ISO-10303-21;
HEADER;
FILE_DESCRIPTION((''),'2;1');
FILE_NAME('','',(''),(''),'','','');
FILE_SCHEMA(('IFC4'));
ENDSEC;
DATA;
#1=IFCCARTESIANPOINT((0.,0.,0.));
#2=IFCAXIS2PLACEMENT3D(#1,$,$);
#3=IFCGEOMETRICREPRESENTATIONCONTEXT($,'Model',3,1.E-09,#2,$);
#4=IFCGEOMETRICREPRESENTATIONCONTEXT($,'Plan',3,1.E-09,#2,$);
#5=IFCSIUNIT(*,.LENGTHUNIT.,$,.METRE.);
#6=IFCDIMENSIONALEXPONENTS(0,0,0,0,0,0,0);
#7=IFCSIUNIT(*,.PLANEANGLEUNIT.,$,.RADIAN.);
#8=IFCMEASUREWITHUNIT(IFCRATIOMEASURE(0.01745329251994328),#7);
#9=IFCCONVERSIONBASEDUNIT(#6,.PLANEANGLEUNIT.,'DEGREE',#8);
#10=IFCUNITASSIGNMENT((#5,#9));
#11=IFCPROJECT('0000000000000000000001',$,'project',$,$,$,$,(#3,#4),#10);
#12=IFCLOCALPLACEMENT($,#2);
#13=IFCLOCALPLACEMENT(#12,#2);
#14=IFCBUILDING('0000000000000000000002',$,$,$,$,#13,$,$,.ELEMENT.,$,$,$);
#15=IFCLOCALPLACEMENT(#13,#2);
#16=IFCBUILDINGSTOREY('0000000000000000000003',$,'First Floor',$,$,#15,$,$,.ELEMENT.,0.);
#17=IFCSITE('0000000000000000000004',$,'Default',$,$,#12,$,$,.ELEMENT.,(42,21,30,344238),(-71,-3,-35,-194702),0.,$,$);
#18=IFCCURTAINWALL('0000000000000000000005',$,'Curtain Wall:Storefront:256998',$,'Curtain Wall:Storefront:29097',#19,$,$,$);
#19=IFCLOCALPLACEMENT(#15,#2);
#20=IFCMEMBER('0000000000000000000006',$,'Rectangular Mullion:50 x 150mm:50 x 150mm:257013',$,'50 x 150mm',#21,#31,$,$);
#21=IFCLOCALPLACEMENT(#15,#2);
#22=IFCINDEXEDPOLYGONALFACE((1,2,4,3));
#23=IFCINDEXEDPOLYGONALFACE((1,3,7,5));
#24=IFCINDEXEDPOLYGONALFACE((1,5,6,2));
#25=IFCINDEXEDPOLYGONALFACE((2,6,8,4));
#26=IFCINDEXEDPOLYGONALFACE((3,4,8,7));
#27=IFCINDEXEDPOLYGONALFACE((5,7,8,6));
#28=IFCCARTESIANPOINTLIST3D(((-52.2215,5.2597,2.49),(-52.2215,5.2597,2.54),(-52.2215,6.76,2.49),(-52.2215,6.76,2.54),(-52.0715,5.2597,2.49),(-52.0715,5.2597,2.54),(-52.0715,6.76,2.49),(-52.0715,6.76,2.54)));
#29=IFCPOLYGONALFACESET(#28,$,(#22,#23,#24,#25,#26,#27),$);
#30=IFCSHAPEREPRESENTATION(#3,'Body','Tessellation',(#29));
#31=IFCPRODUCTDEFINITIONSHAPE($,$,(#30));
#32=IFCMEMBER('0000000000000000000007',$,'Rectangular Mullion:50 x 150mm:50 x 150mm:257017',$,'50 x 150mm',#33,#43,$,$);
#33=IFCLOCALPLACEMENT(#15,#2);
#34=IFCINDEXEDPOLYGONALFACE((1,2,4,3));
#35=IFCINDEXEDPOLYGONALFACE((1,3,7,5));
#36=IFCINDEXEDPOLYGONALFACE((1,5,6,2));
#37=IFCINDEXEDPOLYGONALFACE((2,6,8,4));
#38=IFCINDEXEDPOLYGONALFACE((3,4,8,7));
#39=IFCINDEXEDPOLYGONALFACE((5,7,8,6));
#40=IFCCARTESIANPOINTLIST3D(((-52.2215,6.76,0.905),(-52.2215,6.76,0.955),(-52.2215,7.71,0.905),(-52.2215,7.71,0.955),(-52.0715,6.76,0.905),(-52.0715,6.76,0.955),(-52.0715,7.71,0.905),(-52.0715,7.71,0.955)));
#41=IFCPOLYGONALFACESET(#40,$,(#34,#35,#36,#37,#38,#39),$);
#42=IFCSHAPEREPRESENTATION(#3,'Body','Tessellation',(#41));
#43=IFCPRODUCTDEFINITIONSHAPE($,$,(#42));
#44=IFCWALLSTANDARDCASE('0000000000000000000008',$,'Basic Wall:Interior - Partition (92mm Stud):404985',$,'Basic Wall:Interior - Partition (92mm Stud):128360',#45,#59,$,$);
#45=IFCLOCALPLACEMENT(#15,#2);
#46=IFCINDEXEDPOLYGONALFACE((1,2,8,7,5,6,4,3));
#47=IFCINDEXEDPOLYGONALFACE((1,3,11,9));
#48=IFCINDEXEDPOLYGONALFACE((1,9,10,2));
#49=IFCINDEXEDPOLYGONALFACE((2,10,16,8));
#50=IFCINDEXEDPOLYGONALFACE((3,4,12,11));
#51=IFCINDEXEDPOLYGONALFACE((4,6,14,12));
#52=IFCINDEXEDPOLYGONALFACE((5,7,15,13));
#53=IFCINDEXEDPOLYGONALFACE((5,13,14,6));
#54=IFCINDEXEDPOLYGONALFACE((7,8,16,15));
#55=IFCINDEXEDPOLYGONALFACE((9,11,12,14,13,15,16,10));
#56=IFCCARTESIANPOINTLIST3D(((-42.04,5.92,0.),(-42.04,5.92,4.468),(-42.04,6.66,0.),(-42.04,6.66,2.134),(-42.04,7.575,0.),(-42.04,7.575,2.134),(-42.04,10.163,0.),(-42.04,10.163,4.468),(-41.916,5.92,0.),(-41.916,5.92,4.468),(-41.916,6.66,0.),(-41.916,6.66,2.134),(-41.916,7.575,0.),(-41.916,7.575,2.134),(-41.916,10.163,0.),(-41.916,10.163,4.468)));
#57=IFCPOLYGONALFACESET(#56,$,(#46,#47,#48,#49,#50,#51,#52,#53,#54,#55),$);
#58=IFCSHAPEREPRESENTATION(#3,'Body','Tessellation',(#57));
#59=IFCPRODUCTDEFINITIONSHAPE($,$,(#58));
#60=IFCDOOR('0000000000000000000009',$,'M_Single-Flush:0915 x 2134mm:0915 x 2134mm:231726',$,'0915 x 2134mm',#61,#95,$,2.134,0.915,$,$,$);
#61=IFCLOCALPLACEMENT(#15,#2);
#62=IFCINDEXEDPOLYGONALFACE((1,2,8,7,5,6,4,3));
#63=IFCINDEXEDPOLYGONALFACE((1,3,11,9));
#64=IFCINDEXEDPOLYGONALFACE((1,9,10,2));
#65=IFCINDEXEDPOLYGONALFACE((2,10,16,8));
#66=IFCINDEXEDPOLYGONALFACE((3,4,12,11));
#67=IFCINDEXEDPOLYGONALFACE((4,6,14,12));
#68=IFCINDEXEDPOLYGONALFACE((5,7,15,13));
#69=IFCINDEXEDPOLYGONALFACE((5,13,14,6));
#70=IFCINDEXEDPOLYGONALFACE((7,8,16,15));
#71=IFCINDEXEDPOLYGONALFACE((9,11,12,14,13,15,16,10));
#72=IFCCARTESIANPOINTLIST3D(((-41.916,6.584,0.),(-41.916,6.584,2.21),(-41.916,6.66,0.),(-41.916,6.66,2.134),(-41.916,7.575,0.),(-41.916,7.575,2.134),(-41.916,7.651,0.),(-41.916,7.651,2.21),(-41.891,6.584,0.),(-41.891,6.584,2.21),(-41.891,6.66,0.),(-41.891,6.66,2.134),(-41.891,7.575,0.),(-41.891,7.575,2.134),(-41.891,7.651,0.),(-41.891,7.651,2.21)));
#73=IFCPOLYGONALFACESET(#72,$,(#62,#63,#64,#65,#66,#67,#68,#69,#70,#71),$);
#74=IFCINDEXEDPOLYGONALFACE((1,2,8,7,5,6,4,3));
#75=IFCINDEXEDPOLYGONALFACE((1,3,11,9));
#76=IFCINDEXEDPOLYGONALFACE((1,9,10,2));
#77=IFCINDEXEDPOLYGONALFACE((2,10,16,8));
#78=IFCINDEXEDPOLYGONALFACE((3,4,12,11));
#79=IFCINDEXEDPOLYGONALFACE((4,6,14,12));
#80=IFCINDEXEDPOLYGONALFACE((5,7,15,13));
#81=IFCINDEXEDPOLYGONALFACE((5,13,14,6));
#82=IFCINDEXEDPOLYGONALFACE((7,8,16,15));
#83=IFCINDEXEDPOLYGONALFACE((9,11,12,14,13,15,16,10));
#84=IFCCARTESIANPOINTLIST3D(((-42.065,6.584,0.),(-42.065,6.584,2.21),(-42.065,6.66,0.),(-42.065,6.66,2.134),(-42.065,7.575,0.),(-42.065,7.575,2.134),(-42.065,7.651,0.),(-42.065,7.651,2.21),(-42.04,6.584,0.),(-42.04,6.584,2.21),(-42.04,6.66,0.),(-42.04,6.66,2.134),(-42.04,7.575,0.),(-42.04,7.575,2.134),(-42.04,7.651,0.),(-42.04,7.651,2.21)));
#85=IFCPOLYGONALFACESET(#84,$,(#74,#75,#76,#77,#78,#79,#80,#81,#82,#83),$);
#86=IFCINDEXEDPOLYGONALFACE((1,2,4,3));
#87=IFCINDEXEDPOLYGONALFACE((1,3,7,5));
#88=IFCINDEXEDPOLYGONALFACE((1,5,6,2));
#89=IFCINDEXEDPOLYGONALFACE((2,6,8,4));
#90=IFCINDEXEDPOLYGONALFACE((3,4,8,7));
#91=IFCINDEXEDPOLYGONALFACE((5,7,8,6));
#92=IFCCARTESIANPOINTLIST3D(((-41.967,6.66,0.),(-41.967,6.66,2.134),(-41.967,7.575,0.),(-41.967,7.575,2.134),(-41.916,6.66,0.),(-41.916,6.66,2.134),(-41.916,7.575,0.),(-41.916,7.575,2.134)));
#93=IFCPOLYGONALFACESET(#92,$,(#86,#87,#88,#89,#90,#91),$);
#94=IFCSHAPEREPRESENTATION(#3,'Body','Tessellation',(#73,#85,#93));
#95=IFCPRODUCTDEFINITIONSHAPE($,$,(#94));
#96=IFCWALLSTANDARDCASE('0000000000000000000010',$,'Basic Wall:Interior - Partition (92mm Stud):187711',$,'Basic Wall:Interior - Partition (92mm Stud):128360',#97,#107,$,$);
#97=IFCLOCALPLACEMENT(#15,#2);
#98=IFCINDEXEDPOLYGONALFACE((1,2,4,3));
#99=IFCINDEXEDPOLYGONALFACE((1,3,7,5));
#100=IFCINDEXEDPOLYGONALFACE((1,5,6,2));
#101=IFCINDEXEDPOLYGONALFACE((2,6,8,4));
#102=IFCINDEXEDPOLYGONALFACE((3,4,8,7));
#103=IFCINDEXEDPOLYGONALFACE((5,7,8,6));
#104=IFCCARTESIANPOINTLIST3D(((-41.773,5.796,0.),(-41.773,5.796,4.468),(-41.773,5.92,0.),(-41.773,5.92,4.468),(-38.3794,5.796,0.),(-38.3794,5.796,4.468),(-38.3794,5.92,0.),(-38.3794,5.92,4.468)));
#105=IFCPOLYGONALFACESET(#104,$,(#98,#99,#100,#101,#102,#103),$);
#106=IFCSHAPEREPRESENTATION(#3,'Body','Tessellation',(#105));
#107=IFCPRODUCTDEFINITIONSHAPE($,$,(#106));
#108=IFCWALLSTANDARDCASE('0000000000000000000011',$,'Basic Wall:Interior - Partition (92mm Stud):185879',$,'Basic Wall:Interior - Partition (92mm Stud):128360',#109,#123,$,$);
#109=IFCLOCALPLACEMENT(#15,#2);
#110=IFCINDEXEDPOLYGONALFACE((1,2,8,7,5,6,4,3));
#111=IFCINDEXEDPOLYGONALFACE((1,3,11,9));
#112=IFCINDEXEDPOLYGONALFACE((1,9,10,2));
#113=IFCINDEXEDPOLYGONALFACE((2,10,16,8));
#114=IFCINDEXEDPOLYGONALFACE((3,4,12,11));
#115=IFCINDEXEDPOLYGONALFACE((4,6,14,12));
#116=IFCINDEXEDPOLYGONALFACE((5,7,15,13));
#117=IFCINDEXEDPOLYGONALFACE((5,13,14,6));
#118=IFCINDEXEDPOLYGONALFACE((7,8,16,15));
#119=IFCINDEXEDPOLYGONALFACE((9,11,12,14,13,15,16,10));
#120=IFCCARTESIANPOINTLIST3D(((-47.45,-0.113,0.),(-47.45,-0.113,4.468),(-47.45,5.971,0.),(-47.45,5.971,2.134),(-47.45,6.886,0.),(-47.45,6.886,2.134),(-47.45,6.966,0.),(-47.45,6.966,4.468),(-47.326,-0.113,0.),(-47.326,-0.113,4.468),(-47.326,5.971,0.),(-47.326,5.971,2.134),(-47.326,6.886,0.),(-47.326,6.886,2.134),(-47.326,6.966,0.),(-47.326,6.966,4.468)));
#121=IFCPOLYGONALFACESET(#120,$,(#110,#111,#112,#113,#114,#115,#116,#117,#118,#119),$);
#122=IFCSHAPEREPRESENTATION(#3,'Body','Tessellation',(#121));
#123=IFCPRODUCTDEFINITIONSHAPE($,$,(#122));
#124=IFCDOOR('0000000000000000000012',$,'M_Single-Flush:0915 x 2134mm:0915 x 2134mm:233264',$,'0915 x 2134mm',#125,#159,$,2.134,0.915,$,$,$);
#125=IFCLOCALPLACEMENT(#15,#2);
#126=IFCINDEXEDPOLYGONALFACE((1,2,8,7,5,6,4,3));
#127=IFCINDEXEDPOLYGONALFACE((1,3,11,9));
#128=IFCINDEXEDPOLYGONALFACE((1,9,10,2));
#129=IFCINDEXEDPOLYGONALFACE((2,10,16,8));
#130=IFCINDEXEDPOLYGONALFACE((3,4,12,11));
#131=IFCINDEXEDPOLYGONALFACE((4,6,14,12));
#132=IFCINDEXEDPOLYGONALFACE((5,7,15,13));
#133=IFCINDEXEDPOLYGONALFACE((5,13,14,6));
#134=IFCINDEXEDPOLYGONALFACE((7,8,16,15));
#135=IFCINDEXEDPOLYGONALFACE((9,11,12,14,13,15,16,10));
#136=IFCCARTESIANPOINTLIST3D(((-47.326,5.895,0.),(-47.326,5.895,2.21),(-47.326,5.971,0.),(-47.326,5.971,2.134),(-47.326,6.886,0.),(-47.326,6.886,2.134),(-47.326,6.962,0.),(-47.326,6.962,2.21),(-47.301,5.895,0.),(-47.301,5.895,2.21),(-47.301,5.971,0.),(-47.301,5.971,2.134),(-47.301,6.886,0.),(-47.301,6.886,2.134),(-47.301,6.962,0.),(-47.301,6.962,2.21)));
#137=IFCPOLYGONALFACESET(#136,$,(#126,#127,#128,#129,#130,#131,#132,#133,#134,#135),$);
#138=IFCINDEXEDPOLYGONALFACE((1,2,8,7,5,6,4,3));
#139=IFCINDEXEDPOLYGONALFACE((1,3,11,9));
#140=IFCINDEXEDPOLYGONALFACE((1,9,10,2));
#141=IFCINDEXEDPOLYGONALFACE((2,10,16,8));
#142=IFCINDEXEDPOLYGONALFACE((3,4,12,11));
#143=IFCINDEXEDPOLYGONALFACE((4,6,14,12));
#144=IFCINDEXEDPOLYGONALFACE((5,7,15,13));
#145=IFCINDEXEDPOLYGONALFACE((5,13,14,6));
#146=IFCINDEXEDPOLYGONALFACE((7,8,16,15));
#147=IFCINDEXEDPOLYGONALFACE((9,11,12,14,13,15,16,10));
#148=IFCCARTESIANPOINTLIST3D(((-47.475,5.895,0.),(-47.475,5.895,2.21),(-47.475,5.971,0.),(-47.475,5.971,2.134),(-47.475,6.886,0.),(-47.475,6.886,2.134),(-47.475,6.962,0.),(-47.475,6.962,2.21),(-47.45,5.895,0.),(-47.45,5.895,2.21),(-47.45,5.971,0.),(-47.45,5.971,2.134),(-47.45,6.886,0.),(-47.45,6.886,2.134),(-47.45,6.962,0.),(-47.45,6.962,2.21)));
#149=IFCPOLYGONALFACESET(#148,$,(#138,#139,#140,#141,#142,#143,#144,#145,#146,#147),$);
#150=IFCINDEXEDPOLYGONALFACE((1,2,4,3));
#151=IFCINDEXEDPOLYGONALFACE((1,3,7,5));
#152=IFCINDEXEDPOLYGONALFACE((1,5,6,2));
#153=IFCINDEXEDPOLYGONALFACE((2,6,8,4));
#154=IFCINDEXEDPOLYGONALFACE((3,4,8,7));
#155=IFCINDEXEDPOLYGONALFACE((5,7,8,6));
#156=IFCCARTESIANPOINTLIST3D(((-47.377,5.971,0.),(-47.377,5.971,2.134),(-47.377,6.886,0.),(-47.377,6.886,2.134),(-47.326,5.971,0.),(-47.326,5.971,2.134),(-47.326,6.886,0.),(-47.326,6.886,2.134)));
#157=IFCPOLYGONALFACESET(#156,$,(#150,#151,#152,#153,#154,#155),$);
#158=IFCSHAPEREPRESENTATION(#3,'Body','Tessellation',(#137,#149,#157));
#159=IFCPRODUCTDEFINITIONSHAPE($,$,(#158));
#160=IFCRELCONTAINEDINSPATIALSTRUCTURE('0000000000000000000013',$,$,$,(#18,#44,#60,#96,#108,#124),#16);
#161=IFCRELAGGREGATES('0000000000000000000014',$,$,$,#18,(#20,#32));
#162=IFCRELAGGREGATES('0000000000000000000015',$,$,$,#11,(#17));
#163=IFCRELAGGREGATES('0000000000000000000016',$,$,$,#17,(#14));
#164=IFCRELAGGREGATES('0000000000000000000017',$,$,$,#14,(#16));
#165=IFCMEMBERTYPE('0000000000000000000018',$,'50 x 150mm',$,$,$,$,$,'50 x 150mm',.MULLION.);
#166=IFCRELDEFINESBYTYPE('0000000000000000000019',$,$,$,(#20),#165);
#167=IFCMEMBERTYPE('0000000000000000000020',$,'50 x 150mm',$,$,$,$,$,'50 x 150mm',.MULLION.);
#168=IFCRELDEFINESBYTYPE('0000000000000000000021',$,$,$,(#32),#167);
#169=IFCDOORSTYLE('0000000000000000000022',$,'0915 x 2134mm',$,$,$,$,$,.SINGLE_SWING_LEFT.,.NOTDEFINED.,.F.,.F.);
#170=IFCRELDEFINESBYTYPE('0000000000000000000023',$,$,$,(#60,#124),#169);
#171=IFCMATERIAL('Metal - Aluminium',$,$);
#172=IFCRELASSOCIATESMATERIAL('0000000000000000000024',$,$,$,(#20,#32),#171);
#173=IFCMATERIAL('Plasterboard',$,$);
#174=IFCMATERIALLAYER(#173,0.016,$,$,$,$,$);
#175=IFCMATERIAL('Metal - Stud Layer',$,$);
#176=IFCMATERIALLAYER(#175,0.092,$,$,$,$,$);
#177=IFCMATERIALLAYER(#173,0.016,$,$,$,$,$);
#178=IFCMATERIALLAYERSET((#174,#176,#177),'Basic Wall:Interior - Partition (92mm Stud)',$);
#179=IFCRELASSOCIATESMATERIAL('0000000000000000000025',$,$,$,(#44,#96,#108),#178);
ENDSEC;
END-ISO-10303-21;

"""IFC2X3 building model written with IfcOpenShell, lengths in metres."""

from ifc_helpers import new_model, entity, si_unit, converted_unit, frame, frame_2d, origin, origin_2d_with_axis, place, context, project, spatial, polyline, rectangle, outline, extrude, source, transform, mapped, material, layer, layer_set, layer_usage, type_object, type_shapes, element, fill, aggregate, save


model = new_model("IFC2X3")

# Units and contexts
model_context = context("Model", 3, precision=1e-09, world=origin())
plan_context = context("Plan", 3, precision=1e-09, world=origin())
ifc_project = project(units=[si_unit("LENGTHUNIT", "METRE"), converted_unit("PLANEANGLEUNIT", "DEGREE", entity("IfcRatioMeasure", 0.01745329251994328), si_unit("PLANEANGLEUNIT", "RADIAN"), dimensions=[0, 0, 0, 0, 0, 0, 0])], contexts=[model_context, plan_context])

# Site, building, storey
site_placement = place(None, origin())
site = spatial("IfcSite", under=ifc_project, at=site_placement, Name="Default", CompositionType="ELEMENT", RefLatitude=(42, 21, 30, 344238), RefLongitude=(-71, -3, -35, -194702), RefElevation=0.0)
building_placement = place(site_placement, origin())
building = spatial("IfcBuilding", under=site, at=building_placement, CompositionType="ELEMENT")
storey_placement = place(building_placement, origin())
storey = spatial("IfcBuildingStorey", under=building, at=storey_placement, Name="First Floor", CompositionType="ELEMENT", Elevation=0.0)

# Curtain wall, members
curtain_wall_placement = place(storey_placement, origin())
curtain_wall = element("IfcCurtainWall", 1, at=curtain_wall_placement, inside=storey, Name="Curtain Wall:Storefront:256998", ObjectType="Curtain Wall:Storefront:29097")
ifc_material_1 = material(Name="Metal - Aluminium")
member_type_1 = type_object("IfcMemberType", Name="50 x 150mm", ElementType="50 x 150mm", PredefinedType="MULLION")
shared_shape_1 = source(origin(), model_context, "Body", "SweptSolid", [
    extrude(rectangle(XDim=0.05, YDim=0.15, at=origin_2d_with_axis()), frame((-0.025, 0.0, -1.5003), z_axis=(0.0, 0.0, 1.0), x_axis=(-1.0, 0.0, 0.0)), (0.0, 0.0, 1.0), 1.5003),
])
type_shapes(member_type_1, [shared_shape_1])
member_1_placement = place(storey_placement, frame((-52.1465, 6.76, 2.54), z_axis=(0.0, 1.0, 0.0), x_axis=(0.0, 0.0, 1.0)))
member_1 = element("IfcMember", 2, at=member_1_placement, type_object=member_type_1, material=ifc_material_1, Name="Rectangular Mullion:50 x 150mm:50 x 150mm:257013", ObjectType="50 x 150mm", context=model_context, shape_type="MappedRepresentation", body=[
    mapped(shared_shape_1, transform((0.0, 0.0, 0.0), scale=1.0)),
])
member_type_2 = type_object("IfcMemberType", Name="50 x 150mm", ElementType="50 x 150mm", PredefinedType="MULLION")
shared_shape_2 = source(origin(), model_context, "Body", "SweptSolid", [
    extrude(rectangle(XDim=0.05, YDim=0.15, at=origin_2d_with_axis()), frame((-0.025, 0.0, -0.95), z_axis=(0.0, 0.0, 1.0), x_axis=(-1.0, 0.0, 0.0)), (0.0, 0.0, 1.0), 0.95),
])
type_shapes(member_type_2, [shared_shape_2])
member_2_placement = place(storey_placement, frame((-52.1465, 6.76, 0.905), z_axis=(0.0, -1.0, 0.0), x_axis=(0.0, 0.0, -1.0)))
member_2 = element("IfcMember", 3, at=member_2_placement, type_object=member_type_2, material=ifc_material_1, Name="Rectangular Mullion:50 x 150mm:50 x 150mm:257017", ObjectType="50 x 150mm", context=model_context, shape_type="MappedRepresentation", body=[
    mapped(shared_shape_2, transform((0.0, 0.0, 0.0), scale=1.0)),
])
aggregate(curtain_wall, [member_1, member_2])

# Wall, opening, door
ifc_material_2 = material(Name="Plasterboard")
ifc_layer_1 = layer(ifc_material_2, 0.016)
ifc_material_3 = material(Name="Metal - Stud Layer")
ifc_layer_2 = layer(ifc_material_3, 0.092)
ifc_layer_3 = layer(ifc_material_2, 0.016)
ifc_layer_set_1 = layer_set([ifc_layer_1, ifc_layer_2, ifc_layer_3], Name="Basic Wall:Interior - Partition (92mm Stud)")
ifc_layer_usage_1 = layer_usage(ifc_layer_set_1, "AXIS2", "NEGATIVE", 0.062)
wall_1_placement = place(storey_placement, frame((-41.978, 5.92, 0.0), z_axis=(0.0, 0.0, 1.0), x_axis=(0.0, 1.0, 0.0)))
wall_1 = element("IfcWallStandardCase", 4, at=wall_1_placement, inside=storey, material=ifc_layer_usage_1, Name="Basic Wall:Interior - Partition (92mm Stud):404985", ObjectType="Basic Wall:Interior - Partition (92mm Stud):128360", context=model_context, shape_type="SweptSolid", body=[
    extrude(rectangle(XDim=4.243, YDim=0.124, at=frame_2d((2.1215, 0.0), x_axis=(-1.0, 0.0))), origin(), (0.0, 0.0, 1.0), 4.468),
])
opening_1_placement = place(wall_1_placement, frame((1.655, 0.062, 0.0)))
opening_1 = element("IfcOpeningElement", 5, at=opening_1_placement, cuts=wall_1, ObjectType="Opening", context=model_context, shape_type="SweptSolid", body=[
    extrude(rectangle(XDim=0.915, YDim=2.134, at=frame_2d((1.067, 0.4575), x_axis=(0.0, -1.0))), frame((0.0, 0.0, 0.0), z_axis=(0.0, -1.0, 0.0), x_axis=(0.0, 0.0, 1.0)), (0.0, 0.0, 1.0), 0.124),
])
door_style_1 = type_object("IfcDoorStyle", Name="0915 x 2134mm", ConstructionType="NOTDEFINED", OperationType="SINGLE_SWING_LEFT", ParameterTakesPrecedence=False, Sizeable=False)
shared_shape_3 = source(origin(), model_context, "Body", "SweptSolid", [
    extrude(outline(polyline([(-0.5335, -1.124), (0.5335, -1.124), (0.5335, 1.086), (0.4575, 1.086), (0.4575, -1.048), (-0.4575, -1.048), (-0.4575, 1.086), (-0.5335, 1.086), (-0.5335, -1.124)])), frame((0.4575, 0.149, 1.086), z_axis=(0.0, -1.0, 0.0), x_axis=(-1.0, 0.0, 0.0)), (0.0, 0.0, 1.0), 0.025),
    extrude(outline(polyline([(-1.124, -0.5335), (1.086, -0.5335), (1.086, -0.4575), (-1.048, -0.4575), (-1.048, 0.4575), (1.086, 0.4575), (1.086, 0.5335), (-1.124, 0.5335), (-1.124, -0.5335)])), frame((0.4575, 0.0, 1.086), z_axis=(0.0, -1.0, 0.0), x_axis=(0.0, 0.0, -1.0)), (0.0, 0.0, 1.0), 0.025),
    extrude(rectangle(XDim=0.915, YDim=0.051, at=origin_2d_with_axis()), frame((0.4575, 0.0985, 0.0)), (0.0, 0.0, 1.0), 2.134),
])
type_shapes(door_style_1, [shared_shape_3])
door_1_placement = place(opening_1_placement, frame((0.0, 0.0, 0.0), z_axis=(0.0, 0.0, 1.0), x_axis=(-1.0, 0.0, 0.0)))
door_1 = element("IfcDoor", 6, at=door_1_placement, inside=storey, type_object=door_style_1, Name="M_Single-Flush:0915 x 2134mm:0915 x 2134mm:231726", ObjectType="0915 x 2134mm", OverallHeight=2.134, OverallWidth=0.915, context=model_context, shape_type="MappedRepresentation", body=[
    mapped(shared_shape_3, transform((0.0, 0.0, 0.0), scale=1.0)),
])
fill(opening_1, door_1)

# Wall
wall_2_placement = place(storey_placement, frame((-41.773, 5.858, 0.0)))
element("IfcWallStandardCase", 7, at=wall_2_placement, inside=storey, material=ifc_layer_usage_1, Name="Basic Wall:Interior - Partition (92mm Stud):187711", ObjectType="Basic Wall:Interior - Partition (92mm Stud):128360", context=model_context, shape_type="SweptSolid", body=[
    extrude(rectangle(XDim=3.3936, YDim=0.124, at=frame_2d((1.6968, 0.0), x_axis=(-1.0, 0.0))), origin(), (0.0, 0.0, 1.0), 4.468),
])

# Wall, opening, door
wall_3_placement = place(storey_placement, frame((-47.388, -0.113, 0.0), z_axis=(0.0, 0.0, 1.0), x_axis=(0.0, 1.0, 0.0)))
wall_3 = element("IfcWallStandardCase", 8, at=wall_3_placement, inside=storey, material=ifc_layer_usage_1, Name="Basic Wall:Interior - Partition (92mm Stud):185879", ObjectType="Basic Wall:Interior - Partition (92mm Stud):128360", context=model_context, shape_type="SweptSolid", body=[
    extrude(rectangle(XDim=7.079, YDim=0.124, at=frame_2d((3.5395, 0.0), x_axis=(-1.0, 0.0))), origin(), (0.0, 0.0, 1.0), 4.468),
])
opening_2_placement = place(wall_3_placement, frame((6.999, 0.062, 0.0)))
opening_2 = element("IfcOpeningElement", 9, at=opening_2_placement, cuts=wall_3, ObjectType="Opening", context=model_context, shape_type="SweptSolid", body=[
    extrude(rectangle(XDim=0.915, YDim=2.134, at=frame_2d((1.067, 0.4575), x_axis=(0.0, -1.0))), frame((0.0, 0.0, 0.0), z_axis=(0.0, -1.0, 0.0), x_axis=(0.0, 0.0, 1.0)), (0.0, 0.0, 1.0), 0.124),
])
door_2_placement = place(opening_2_placement, frame((0.0, 0.0, 0.0), z_axis=(0.0, 0.0, 1.0), x_axis=(-1.0, 0.0, 0.0)))
door_2 = element("IfcDoor", 10, at=door_2_placement, inside=storey, type_object=door_style_1, Name="M_Single-Flush:0915 x 2134mm:0915 x 2134mm:233264", ObjectType="0915 x 2134mm", OverallHeight=2.134, OverallWidth=0.915, context=model_context, shape_type="MappedRepresentation", body=[
    mapped(shared_shape_3, transform((0.0, 0.0, 0.0), scale=1.0)),
])
fill(opening_2, door_2)

save(model, "model.ifc")
